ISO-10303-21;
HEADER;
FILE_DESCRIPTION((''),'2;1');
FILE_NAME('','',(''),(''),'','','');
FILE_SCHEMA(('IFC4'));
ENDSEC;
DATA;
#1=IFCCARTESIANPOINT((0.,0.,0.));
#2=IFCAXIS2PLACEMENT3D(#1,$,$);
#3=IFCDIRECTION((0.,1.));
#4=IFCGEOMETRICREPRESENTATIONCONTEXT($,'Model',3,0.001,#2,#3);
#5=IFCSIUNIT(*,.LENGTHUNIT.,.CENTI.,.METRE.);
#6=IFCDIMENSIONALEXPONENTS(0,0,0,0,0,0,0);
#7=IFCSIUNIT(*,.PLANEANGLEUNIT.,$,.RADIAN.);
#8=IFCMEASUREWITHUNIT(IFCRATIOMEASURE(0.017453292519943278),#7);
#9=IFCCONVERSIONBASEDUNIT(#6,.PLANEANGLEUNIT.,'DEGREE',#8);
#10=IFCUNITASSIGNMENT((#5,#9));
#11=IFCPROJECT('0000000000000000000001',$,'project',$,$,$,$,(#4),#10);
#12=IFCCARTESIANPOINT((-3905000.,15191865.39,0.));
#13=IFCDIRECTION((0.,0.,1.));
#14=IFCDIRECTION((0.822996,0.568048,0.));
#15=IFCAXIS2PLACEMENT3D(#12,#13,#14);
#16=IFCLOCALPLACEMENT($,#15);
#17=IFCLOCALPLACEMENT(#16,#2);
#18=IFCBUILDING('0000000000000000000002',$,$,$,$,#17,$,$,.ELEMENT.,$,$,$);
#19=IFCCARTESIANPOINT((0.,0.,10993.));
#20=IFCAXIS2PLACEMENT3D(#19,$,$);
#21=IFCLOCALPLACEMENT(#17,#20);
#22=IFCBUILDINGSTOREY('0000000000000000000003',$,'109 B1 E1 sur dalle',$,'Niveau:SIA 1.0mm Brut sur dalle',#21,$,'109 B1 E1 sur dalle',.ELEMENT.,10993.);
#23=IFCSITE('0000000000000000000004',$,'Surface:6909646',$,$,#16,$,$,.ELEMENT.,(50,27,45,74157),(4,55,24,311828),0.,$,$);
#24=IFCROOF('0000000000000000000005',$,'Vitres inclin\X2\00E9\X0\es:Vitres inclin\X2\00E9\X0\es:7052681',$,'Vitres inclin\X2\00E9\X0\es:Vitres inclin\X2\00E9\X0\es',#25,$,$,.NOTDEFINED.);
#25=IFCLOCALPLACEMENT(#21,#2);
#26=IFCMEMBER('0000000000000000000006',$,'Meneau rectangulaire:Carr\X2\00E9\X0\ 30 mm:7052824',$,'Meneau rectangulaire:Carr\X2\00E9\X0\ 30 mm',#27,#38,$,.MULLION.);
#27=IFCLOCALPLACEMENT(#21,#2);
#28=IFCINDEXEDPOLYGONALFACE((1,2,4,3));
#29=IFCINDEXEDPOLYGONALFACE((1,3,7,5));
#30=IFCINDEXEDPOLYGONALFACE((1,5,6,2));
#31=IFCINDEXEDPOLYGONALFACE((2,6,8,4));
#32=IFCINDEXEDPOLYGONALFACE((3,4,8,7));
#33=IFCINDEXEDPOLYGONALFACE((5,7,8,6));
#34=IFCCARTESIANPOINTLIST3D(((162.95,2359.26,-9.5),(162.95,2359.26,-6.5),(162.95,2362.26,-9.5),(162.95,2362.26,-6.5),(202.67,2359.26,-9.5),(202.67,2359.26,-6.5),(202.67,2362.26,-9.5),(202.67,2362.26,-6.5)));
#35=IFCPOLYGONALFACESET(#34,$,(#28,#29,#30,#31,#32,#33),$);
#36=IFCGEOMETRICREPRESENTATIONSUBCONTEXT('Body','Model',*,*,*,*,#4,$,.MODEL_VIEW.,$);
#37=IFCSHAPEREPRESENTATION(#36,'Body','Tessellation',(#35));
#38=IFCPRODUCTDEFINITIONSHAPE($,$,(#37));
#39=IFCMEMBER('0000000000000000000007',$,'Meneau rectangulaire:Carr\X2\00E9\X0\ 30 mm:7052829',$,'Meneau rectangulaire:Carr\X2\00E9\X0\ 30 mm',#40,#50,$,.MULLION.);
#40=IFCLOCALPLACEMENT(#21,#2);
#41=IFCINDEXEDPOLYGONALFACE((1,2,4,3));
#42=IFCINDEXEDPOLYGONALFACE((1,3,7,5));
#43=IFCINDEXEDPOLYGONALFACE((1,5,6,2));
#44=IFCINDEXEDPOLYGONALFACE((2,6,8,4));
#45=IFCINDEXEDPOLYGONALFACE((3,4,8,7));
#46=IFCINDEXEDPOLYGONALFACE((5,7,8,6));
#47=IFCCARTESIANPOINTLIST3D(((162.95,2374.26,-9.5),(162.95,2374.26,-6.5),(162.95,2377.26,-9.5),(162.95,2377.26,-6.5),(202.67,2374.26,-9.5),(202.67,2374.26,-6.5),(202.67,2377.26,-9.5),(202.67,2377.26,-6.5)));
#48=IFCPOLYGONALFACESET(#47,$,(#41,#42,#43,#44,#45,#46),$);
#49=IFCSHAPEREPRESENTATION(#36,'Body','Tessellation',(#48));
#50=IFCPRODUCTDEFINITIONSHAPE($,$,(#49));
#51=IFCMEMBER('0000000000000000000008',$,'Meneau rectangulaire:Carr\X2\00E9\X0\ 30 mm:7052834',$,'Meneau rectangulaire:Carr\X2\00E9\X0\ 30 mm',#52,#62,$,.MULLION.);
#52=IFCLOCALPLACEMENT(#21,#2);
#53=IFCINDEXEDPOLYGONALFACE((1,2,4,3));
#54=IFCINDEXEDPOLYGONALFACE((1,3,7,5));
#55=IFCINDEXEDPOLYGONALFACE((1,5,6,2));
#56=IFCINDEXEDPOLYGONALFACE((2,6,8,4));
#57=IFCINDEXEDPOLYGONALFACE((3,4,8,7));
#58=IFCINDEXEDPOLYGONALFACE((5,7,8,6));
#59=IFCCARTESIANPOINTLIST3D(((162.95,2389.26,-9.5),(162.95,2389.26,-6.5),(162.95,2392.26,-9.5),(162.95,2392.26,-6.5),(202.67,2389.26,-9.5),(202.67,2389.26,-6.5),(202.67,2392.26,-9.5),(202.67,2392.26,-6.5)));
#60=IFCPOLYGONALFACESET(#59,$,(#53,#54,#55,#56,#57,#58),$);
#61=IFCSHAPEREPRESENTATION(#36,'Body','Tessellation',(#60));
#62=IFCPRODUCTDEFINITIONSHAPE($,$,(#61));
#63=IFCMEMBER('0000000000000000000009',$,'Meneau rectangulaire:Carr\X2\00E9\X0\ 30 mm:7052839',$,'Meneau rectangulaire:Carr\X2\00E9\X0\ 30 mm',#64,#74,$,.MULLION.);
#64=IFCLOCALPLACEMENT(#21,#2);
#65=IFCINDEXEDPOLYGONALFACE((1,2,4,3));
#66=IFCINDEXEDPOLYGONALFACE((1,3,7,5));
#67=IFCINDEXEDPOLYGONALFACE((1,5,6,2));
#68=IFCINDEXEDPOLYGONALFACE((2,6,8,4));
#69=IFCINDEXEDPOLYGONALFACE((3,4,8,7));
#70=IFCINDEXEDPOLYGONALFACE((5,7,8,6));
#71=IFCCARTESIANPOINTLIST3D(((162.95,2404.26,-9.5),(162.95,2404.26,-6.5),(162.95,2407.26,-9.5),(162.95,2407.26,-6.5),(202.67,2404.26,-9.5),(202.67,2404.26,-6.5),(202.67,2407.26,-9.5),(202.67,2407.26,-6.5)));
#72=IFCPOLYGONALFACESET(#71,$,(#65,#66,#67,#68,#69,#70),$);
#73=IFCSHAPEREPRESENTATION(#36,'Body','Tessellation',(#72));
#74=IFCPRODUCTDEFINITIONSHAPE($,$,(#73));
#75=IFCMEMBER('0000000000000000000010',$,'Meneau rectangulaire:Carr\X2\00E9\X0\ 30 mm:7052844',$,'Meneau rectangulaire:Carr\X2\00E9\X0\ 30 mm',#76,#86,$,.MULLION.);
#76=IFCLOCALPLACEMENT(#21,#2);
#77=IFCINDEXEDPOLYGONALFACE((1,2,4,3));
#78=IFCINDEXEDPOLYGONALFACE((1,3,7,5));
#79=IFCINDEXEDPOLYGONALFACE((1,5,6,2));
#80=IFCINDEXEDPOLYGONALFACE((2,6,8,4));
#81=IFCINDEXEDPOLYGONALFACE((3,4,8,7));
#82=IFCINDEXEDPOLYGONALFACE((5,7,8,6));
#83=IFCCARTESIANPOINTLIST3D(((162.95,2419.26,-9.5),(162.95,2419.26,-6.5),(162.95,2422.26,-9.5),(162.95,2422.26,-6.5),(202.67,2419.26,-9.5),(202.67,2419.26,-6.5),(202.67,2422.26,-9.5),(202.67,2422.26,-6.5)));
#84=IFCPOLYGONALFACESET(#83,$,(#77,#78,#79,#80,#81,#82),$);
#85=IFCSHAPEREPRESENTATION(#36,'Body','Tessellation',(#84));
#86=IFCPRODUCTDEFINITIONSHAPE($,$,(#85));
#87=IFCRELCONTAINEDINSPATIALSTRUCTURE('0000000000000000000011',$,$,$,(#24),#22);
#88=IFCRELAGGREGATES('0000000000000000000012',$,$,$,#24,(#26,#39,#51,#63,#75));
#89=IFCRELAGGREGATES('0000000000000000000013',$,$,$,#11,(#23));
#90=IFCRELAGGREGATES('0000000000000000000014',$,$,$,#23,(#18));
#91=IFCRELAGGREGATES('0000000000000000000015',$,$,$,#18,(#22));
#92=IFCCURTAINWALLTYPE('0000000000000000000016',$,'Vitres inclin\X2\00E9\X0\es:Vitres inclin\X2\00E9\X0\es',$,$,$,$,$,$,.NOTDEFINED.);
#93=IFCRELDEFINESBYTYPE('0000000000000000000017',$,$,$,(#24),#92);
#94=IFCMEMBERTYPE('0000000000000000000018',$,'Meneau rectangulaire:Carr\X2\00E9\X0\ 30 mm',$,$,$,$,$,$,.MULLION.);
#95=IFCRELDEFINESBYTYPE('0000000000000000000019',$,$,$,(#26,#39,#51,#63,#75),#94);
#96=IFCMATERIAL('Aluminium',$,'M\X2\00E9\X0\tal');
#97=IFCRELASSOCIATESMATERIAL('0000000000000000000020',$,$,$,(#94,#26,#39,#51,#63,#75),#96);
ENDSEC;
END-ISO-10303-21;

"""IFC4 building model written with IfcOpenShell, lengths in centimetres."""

from ifc_helpers import new_model, entity, si_unit, converted_unit, direction, frame, origin, place, context, subcontext, project, spatial, indexed_curve, outline, extrude, source, transform, mapped, material, type_object, type_shapes, element, aggregate, save


model = new_model("IFC4")

# Units and contexts
model_context = context("Model", 3, precision=0.001, world=origin(), true_north=direction((0.0, 1.0)))
body_context = subcontext(model_context, "Body", "Model", "MODEL_VIEW")
ifc_project = project(units=[si_unit("LENGTHUNIT", "METRE", prefix="CENTI"), converted_unit("PLANEANGLEUNIT", "DEGREE", entity("IfcRatioMeasure", 0.017453292519943278), si_unit("PLANEANGLEUNIT", "RADIAN"), dimensions=[0, 0, 0, 0, 0, 0, 0])], contexts=[model_context])

# Site, building, storey
site_placement = place(None, frame((-3905000.0, 15191865.39, 0.0), z_axis=(0.0, 0.0, 1.0), x_axis=(0.822996, 0.568048, 0.0)))
site = spatial("IfcSite", under=ifc_project, at=site_placement, Name="Surface:6909646", CompositionType="ELEMENT", RefLatitude=(50, 27, 45, 74157), RefLongitude=(4, 55, 24, 311828), RefElevation=0.0)
building_placement = place(site_placement, origin())
building = spatial("IfcBuilding", under=site, at=building_placement, CompositionType="ELEMENT")
storey_placement = place(building_placement, frame((0.0, 0.0, 10993.0)))
storey = spatial("IfcBuildingStorey", under=building, at=storey_placement, Name="109 B1 E1 sur dalle", ObjectType="Niveau:SIA 1.0mm Brut sur dalle", LongName="109 B1 E1 sur dalle", CompositionType="ELEMENT", Elevation=10993.0)

# Roof, members
curtain_wall_type = type_object("IfcCurtainWallType", Name="Vitres inclinées:Vitres inclinées", PredefinedType="NOTDEFINED")
roof_placement = place(storey_placement, frame((0.0, 0.0, -10993.0)))
roof = element("IfcRoof", 1, at=roof_placement, inside=storey, type_object=curtain_wall_type, Name="Vitres inclinées:Vitres inclinées:7052681", ObjectType="Vitres inclinées:Vitres inclinées", PredefinedType="NOTDEFINED")
ifc_material = material(Name="Aluminium", Category="Métal")
member_type_1 = type_object("IfcMemberType", Name="Meneau rectangulaire:Carré 30 mm", PredefinedType="MULLION", material=ifc_material)
shared_shape_1 = source(origin(), body_context, "Body", "SweptSolid", [
    extrude(outline(indexed_curve([(-1.5, -1.5), (1.5, -1.5), (1.5, 1.5), (-1.5, 1.5), (-1.5, -1.5)], self_intersect=False)), frame((0.0, 0.0, -39.72), z_axis=(0.0, 0.0, 1.0), x_axis=(0.0, -1.0, 0.0)), (0.0, 0.0, 1.0), 39.72),
])
type_shapes(member_type_1, [shared_shape_1])
member_1_placement = place(roof_placement, frame((162.95, 2360.76, 10985.0), z_axis=(-1.0, 0.0, 0.0), x_axis=(0.0, 1.0, 0.0)))
member_1 = element("IfcMember", 2, at=member_1_placement, type_object=member_type_1, material=ifc_material, Name="Meneau rectangulaire:Carré 30 mm:7052824", ObjectType="Meneau rectangulaire:Carré 30 mm", PredefinedType="MULLION", context=body_context, shape_type="MappedRepresentation", body=[
    mapped(shared_shape_1, transform((0.0, 0.0, 0.0), scale=1.0)),
])
member_2_placement = place(roof_placement, frame((162.95, 2375.76, 10985.0), z_axis=(-1.0, 0.0, 0.0), x_axis=(0.0, 1.0, 0.0)))
member_2 = element("IfcMember", 3, at=member_2_placement, type_object=member_type_1, material=ifc_material, Name="Meneau rectangulaire:Carré 30 mm:7052829", ObjectType="Meneau rectangulaire:Carré 30 mm", PredefinedType="MULLION", context=body_context, shape_type="MappedRepresentation", body=[
    mapped(shared_shape_1, transform((0.0, 0.0, 0.0), scale=1.0)),
])
member_3_placement = place(roof_placement, frame((162.95, 2390.76, 10985.0), z_axis=(-1.0, 0.0, 0.0), x_axis=(0.0, 1.0, 0.0)))
member_3 = element("IfcMember", 4, at=member_3_placement, type_object=member_type_1, material=ifc_material, Name="Meneau rectangulaire:Carré 30 mm:7052834", ObjectType="Meneau rectangulaire:Carré 30 mm", PredefinedType="MULLION", context=body_context, shape_type="MappedRepresentation", body=[
    mapped(shared_shape_1, transform((0.0, 0.0, 0.0), scale=1.0)),
])
member_4_placement = place(roof_placement, frame((162.95, 2405.76, 10985.0), z_axis=(-1.0, 0.0, 0.0), x_axis=(0.0, 1.0, 0.0)))
member_4 = element("IfcMember", 5, at=member_4_placement, type_object=member_type_1, material=ifc_material, Name="Meneau rectangulaire:Carré 30 mm:7052839", ObjectType="Meneau rectangulaire:Carré 30 mm", PredefinedType="MULLION", context=body_context, shape_type="MappedRepresentation", body=[
    mapped(shared_shape_1, transform((0.0, 0.0, 0.0), scale=1.0)),
])
member_5_placement = place(roof_placement, frame((162.95, 2420.76, 10985.0), z_axis=(-1.0, 0.0, 0.0), x_axis=(0.0, 1.0, 0.0)))
member_5 = element("IfcMember", 6, at=member_5_placement, type_object=member_type_1, material=ifc_material, Name="Meneau rectangulaire:Carré 30 mm:7052844", ObjectType="Meneau rectangulaire:Carré 30 mm", PredefinedType="MULLION", context=body_context, shape_type="MappedRepresentation", body=[
    mapped(shared_shape_1, transform((0.0, 0.0, 0.0), scale=1.0)),
])
aggregate(roof, [member_1, member_2, member_3, member_4, member_5])

save(model, "model.ifc")
